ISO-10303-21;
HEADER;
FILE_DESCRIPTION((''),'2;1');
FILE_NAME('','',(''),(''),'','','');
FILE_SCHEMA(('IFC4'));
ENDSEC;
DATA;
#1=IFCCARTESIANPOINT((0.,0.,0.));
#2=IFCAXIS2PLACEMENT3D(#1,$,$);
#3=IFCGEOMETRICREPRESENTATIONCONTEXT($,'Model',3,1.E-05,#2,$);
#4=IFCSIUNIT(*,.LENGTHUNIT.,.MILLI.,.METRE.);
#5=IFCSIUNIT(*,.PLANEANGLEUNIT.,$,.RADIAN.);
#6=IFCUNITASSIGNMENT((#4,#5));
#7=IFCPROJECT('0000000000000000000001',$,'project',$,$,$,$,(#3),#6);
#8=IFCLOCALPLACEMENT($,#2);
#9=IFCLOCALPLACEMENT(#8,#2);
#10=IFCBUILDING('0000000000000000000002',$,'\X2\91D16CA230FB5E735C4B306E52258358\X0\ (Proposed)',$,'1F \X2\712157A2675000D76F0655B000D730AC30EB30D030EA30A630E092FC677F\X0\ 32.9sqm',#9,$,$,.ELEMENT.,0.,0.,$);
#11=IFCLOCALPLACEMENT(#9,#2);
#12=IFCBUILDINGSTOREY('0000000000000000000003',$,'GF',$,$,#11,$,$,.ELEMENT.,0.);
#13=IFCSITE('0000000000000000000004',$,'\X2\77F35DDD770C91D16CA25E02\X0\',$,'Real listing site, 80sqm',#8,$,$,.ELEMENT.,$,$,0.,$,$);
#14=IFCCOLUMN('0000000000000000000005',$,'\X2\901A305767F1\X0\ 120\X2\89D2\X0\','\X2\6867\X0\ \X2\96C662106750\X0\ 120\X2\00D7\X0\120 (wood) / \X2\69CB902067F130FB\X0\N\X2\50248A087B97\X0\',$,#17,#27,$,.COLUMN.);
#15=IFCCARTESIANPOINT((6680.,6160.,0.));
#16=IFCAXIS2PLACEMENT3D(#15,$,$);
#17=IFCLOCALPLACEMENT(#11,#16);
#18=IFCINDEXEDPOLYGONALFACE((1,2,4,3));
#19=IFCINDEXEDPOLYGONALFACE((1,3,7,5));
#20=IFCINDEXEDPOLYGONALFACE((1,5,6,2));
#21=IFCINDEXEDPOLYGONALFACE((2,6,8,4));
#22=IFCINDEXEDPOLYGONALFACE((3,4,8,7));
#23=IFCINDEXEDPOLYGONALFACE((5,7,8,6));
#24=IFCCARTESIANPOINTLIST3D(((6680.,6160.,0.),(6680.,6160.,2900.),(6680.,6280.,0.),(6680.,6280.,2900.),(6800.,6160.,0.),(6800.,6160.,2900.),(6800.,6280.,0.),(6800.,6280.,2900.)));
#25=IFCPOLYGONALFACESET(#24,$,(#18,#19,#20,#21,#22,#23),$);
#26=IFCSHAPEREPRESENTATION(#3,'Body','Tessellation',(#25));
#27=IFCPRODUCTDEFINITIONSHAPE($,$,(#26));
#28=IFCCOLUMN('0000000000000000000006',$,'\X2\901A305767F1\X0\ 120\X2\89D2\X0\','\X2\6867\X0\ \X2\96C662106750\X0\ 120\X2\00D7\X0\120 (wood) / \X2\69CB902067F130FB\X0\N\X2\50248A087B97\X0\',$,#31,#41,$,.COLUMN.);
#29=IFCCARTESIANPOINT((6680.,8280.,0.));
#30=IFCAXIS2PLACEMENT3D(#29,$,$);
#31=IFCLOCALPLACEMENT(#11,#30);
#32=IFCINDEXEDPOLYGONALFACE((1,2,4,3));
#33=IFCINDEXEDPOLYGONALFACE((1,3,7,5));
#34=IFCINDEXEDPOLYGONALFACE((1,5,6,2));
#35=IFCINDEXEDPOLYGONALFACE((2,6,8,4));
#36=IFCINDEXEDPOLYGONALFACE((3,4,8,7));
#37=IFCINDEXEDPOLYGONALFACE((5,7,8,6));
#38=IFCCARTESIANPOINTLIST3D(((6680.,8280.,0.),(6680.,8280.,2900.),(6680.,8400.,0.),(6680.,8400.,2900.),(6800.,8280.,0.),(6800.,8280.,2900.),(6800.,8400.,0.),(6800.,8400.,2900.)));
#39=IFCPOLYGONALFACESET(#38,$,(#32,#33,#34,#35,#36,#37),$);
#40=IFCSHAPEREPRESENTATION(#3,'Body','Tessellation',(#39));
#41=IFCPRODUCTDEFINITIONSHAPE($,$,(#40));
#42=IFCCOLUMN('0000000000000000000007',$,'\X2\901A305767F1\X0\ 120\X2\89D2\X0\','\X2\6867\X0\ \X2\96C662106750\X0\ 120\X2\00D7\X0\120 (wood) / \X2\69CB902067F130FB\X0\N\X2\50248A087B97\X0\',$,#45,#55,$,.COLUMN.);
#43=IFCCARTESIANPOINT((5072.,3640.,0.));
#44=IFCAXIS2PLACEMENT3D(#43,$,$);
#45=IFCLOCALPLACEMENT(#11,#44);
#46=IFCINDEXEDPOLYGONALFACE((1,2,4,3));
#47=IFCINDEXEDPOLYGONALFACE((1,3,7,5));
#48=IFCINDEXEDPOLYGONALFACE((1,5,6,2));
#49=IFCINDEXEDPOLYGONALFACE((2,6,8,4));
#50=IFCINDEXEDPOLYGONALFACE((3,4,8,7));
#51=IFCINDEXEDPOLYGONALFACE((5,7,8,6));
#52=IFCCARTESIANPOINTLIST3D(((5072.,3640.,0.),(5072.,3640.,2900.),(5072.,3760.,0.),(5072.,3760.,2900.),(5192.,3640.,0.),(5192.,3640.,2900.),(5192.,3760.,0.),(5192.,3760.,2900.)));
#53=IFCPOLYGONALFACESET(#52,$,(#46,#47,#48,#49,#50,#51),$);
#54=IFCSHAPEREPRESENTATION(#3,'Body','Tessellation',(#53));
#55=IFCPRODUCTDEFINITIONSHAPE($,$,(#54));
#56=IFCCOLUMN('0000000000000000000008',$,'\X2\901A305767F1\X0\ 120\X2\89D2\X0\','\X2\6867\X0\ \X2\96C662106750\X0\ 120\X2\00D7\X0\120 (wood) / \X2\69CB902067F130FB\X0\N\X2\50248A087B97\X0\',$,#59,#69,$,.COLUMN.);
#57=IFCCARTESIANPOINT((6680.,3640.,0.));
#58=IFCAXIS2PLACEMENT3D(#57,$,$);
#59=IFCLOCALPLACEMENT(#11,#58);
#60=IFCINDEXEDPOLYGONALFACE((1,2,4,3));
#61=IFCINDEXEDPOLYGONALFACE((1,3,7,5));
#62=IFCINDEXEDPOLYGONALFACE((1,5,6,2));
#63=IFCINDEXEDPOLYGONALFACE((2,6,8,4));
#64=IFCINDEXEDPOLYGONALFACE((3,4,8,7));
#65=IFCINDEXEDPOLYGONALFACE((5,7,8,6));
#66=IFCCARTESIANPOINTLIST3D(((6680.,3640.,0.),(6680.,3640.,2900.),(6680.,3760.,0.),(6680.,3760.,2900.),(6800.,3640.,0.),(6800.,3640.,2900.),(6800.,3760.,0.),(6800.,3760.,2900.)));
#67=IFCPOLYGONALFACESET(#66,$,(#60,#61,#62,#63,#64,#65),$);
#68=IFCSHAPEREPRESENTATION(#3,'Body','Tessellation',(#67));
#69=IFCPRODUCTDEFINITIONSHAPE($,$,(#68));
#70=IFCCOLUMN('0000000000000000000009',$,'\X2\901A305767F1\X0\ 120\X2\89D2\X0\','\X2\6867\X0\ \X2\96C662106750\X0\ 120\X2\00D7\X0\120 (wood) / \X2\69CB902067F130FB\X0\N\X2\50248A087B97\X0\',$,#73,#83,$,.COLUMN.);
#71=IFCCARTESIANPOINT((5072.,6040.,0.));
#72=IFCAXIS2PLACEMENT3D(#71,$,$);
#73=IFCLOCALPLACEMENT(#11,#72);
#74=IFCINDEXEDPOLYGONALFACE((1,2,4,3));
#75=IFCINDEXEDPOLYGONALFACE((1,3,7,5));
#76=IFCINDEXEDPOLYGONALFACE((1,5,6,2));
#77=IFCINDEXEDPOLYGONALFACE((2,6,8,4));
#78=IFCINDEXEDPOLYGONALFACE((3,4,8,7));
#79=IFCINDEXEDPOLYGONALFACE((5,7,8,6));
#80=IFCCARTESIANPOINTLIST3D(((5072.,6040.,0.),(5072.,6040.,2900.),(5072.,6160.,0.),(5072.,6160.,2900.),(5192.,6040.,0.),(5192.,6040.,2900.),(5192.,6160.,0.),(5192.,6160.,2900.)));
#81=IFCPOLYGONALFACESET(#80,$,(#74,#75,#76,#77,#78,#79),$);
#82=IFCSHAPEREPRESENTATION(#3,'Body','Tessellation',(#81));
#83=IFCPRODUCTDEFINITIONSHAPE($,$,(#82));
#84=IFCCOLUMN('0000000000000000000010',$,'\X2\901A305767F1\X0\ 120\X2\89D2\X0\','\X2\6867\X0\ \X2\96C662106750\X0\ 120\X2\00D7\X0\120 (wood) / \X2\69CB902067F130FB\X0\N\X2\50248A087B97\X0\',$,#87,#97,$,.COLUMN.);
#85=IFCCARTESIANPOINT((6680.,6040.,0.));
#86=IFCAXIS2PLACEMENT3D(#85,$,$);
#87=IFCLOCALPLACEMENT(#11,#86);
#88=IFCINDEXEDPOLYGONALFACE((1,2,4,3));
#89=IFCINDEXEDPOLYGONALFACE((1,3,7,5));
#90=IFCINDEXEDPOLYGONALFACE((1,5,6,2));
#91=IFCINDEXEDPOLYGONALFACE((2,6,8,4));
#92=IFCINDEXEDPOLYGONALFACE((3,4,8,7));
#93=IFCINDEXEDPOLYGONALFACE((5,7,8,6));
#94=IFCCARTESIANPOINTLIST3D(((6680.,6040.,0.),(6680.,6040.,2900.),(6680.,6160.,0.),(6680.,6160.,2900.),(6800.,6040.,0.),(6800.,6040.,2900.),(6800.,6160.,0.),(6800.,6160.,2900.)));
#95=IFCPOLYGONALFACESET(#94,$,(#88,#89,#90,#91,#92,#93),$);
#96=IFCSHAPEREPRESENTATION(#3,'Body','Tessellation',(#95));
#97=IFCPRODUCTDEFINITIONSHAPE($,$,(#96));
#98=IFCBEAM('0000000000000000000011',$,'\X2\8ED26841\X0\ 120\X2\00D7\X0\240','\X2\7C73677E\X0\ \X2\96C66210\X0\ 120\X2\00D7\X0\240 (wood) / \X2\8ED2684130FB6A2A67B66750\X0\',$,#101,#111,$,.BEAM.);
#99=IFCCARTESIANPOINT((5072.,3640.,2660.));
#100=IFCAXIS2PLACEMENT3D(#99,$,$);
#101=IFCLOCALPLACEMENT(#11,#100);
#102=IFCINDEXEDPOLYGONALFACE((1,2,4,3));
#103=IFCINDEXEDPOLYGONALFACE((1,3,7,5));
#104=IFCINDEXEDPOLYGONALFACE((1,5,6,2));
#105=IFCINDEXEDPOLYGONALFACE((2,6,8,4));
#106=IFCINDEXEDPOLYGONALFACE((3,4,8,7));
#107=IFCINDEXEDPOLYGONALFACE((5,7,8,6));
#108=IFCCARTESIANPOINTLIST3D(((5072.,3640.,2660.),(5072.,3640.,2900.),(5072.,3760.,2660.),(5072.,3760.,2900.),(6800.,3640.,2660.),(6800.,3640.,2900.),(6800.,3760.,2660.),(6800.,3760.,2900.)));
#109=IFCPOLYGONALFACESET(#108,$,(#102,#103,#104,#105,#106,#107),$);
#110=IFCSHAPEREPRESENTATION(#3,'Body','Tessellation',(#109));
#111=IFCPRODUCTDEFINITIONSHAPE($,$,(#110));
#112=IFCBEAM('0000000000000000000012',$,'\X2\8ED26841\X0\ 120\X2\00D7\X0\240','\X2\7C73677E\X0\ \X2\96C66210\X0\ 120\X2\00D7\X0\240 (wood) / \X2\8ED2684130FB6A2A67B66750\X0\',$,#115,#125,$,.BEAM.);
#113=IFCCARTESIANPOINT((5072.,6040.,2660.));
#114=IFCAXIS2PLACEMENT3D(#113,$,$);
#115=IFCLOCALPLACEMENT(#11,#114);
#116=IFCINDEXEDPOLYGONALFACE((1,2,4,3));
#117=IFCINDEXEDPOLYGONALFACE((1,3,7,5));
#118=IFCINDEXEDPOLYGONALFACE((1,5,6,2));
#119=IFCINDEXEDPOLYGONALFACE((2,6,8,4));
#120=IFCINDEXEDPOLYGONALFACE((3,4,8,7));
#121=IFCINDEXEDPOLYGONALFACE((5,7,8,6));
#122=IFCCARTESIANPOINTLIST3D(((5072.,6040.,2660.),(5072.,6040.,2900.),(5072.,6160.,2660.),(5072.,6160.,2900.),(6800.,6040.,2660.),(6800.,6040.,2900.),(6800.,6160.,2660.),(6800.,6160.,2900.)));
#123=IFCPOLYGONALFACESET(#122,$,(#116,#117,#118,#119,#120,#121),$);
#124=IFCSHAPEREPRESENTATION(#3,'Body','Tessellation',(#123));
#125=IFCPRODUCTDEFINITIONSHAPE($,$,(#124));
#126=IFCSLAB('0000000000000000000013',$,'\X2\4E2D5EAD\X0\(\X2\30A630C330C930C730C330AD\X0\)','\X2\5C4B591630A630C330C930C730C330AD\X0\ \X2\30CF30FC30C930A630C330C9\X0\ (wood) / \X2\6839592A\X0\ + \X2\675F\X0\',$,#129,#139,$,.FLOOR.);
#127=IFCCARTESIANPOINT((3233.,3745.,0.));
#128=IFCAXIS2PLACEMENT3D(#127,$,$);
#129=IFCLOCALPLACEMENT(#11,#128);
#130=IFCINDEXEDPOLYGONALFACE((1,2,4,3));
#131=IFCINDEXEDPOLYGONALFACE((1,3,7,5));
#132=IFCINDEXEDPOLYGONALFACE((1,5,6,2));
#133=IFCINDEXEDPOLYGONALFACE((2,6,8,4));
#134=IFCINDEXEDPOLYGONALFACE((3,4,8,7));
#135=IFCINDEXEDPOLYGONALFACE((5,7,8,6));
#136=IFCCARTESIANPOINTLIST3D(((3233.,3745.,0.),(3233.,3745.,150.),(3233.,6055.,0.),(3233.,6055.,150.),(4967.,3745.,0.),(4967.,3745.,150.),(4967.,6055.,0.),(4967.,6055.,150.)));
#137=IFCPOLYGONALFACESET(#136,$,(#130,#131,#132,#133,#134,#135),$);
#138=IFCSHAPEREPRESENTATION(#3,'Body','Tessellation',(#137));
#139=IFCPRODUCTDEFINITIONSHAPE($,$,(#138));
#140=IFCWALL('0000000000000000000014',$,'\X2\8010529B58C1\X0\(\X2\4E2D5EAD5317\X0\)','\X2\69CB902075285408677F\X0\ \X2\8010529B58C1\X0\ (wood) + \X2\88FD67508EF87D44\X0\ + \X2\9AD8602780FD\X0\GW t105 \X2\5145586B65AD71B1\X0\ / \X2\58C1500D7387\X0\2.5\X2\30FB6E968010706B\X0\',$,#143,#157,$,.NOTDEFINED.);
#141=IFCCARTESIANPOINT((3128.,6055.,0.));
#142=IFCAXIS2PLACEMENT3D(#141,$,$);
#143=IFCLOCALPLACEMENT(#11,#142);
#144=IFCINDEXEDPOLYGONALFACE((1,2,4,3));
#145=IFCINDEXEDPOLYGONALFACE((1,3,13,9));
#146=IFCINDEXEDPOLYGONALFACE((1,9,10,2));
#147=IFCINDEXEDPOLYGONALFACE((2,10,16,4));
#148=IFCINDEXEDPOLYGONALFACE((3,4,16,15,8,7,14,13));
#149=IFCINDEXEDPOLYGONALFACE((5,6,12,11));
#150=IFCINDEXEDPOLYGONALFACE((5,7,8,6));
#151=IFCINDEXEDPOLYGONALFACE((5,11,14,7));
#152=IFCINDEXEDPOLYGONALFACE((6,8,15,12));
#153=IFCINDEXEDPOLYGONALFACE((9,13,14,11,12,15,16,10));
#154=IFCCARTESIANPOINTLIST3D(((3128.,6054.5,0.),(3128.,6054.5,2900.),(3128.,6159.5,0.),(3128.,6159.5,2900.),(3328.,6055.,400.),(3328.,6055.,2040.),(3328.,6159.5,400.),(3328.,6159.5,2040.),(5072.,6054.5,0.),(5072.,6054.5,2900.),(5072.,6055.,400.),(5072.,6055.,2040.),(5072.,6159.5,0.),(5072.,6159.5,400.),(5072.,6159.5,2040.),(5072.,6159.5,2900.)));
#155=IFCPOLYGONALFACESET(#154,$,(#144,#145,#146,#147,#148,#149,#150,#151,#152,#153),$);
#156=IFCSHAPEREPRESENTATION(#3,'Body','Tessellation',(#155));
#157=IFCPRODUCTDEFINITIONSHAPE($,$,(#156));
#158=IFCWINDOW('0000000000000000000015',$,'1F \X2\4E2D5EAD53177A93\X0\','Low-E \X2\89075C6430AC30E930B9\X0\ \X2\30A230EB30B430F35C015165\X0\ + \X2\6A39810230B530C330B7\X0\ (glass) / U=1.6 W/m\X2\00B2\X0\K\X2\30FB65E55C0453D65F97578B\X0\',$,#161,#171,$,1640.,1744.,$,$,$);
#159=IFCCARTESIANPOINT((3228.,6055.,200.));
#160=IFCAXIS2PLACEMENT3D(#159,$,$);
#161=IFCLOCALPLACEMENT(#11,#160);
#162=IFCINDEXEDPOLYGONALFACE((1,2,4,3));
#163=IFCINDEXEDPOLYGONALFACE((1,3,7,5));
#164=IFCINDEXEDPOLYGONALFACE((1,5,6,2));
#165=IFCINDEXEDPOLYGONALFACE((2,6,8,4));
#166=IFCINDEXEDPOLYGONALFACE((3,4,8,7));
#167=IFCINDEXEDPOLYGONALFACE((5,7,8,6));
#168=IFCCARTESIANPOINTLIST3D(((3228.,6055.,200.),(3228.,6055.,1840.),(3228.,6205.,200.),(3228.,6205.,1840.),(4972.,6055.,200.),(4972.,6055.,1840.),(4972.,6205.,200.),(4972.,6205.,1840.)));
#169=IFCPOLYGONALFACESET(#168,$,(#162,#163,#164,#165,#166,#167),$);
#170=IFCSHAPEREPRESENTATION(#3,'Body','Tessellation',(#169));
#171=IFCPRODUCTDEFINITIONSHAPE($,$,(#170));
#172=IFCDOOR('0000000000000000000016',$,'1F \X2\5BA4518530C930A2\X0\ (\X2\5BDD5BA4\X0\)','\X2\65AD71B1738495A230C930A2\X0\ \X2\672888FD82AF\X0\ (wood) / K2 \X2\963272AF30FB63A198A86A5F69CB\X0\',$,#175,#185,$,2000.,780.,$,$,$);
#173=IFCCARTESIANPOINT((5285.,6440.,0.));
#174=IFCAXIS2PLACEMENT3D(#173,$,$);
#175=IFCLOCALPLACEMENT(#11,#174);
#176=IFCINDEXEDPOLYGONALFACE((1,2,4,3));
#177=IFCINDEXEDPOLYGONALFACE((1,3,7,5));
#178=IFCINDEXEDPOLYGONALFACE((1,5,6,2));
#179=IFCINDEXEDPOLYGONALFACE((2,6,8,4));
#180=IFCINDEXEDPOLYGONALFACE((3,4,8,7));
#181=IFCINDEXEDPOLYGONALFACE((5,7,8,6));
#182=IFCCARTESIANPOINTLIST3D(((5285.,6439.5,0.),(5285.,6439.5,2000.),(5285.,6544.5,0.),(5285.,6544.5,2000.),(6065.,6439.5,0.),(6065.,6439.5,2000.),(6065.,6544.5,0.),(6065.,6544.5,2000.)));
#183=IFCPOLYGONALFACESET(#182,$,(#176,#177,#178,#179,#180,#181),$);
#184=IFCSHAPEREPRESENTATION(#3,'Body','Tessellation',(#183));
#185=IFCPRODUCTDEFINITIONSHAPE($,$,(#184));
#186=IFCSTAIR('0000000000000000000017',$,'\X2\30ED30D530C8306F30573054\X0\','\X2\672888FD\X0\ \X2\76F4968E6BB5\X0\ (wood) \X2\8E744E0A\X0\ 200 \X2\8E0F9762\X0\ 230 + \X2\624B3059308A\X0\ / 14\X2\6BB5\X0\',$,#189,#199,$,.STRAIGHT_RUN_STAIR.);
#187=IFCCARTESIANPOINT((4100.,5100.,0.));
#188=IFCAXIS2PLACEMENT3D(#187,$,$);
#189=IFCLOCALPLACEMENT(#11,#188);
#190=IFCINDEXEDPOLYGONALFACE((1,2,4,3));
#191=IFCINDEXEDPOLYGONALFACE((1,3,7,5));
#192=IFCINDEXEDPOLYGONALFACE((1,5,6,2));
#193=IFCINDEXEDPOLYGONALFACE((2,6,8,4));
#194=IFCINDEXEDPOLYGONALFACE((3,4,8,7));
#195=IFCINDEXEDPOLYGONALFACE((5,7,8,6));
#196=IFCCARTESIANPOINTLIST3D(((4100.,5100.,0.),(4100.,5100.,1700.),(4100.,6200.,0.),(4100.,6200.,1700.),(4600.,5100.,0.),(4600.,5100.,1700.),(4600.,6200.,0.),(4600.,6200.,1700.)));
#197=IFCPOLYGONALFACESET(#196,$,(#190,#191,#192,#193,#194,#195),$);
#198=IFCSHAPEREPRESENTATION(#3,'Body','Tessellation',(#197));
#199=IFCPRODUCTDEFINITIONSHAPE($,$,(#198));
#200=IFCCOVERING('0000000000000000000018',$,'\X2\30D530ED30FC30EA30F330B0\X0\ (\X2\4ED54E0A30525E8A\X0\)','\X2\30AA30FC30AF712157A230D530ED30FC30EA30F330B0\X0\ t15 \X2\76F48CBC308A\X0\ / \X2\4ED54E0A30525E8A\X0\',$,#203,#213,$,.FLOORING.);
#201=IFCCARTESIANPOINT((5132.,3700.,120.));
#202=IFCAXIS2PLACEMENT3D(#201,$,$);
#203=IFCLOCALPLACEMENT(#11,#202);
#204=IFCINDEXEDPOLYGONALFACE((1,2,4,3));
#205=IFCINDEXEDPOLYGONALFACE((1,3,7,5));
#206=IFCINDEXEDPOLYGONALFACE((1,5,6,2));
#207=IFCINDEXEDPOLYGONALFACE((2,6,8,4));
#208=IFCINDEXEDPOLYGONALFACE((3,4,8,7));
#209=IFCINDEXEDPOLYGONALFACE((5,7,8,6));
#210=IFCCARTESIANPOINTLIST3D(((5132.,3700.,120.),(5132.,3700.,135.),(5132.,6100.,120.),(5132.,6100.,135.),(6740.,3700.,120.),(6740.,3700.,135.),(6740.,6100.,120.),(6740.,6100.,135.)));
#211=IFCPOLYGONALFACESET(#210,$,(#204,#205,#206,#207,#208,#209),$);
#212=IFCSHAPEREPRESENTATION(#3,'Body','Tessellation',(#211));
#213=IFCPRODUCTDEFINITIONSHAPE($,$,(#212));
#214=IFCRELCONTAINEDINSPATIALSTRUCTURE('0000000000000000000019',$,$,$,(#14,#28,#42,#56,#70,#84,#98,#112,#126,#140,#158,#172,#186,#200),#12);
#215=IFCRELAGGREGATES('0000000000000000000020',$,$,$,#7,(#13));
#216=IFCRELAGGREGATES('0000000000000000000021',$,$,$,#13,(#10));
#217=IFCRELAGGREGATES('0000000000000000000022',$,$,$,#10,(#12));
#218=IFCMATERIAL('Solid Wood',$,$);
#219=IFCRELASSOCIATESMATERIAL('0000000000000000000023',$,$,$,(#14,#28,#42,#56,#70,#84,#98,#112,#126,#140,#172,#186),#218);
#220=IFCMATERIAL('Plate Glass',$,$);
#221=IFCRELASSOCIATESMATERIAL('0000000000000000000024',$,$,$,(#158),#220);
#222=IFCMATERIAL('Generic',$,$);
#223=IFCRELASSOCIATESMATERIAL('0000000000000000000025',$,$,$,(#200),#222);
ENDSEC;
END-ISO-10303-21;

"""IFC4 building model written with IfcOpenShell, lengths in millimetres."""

from ifc_helpers import new_model, si_unit, frame, frame_2d, origin, place, context, project, spatial, rectangle, extrude, material, element, fill, save


model = new_model("IFC4")

# Units and contexts
model_context = context("Model", 3, precision=1e-05, world=origin())
ifc_project = project(units=[si_unit("LENGTHUNIT", "METRE", prefix="MILLI"), si_unit("PLANEANGLEUNIT", "RADIAN")], contexts=[model_context])

# Site, building, storey
site_placement = place(None, origin())
site = spatial("IfcSite", under=ifc_project, at=site_placement, Name="石川県金沢市", ObjectType="Real listing site, 80sqm", CompositionType="ELEMENT", RefElevation=0.0)
building_placement = place(site_placement, origin())
building = spatial("IfcBuilding", under=site, at=building_placement, Name="金沢・平屋の別荘 (Proposed)", ObjectType="1F 無垢材×漆喰×ガルバリウム鋼板 32.9sqm", CompositionType="ELEMENT", ElevationOfRefHeight=0.0, ElevationOfTerrain=0.0)
storey_placement = place(building_placement, origin())
storey = spatial("IfcBuildingStorey", under=building, at=storey_placement, Name="GF", CompositionType="ELEMENT", Elevation=0.0)

# Columns
ifc_material_1 = material(Name="Solid Wood")
column_1_placement = place(storey_placement, frame((6680.0, 6160.0, 0.0)))
element("IfcColumn", 1, at=column_1_placement, inside=storey, material=ifc_material_1, Name="通し柱 120角", Description="桧 集成材 120×120 (wood) / 構造柱・N値計算", PredefinedType="COLUMN", context=model_context, shape_type="SweptSolid", body=[
    extrude(rectangle(XDim=120.0, YDim=120.0, at=frame_2d((60.0, 60.0))), frame((6680.0, 6160.0, 0.0)), (0.0, 0.0, 1.0), 2900.0),
])
column_2_placement = place(storey_placement, frame((6680.0, 8280.0, 0.0)))
element("IfcColumn", 2, at=column_2_placement, inside=storey, material=ifc_material_1, Name="通し柱 120角", Description="桧 集成材 120×120 (wood) / 構造柱・N値計算", PredefinedType="COLUMN", context=model_context, shape_type="SweptSolid", body=[
    extrude(rectangle(XDim=120.0, YDim=120.0, at=frame_2d((60.0, 60.0))), frame((6680.0, 8280.0, 0.0)), (0.0, 0.0, 1.0), 2900.0),
])
column_3_placement = place(storey_placement, frame((5072.0, 3640.0, 0.0)))
element("IfcColumn", 3, at=column_3_placement, inside=storey, material=ifc_material_1, Name="通し柱 120角", Description="桧 集成材 120×120 (wood) / 構造柱・N値計算", PredefinedType="COLUMN", context=model_context, shape_type="SweptSolid", body=[
    extrude(rectangle(XDim=120.0, YDim=120.0, at=frame_2d((60.0, 60.0))), frame((5072.0, 3640.0, 0.0)), (0.0, 0.0, 1.0), 2900.0),
])
column_4_placement = place(storey_placement, frame((6680.0, 3640.0, 0.0)))
element("IfcColumn", 4, at=column_4_placement, inside=storey, material=ifc_material_1, Name="通し柱 120角", Description="桧 集成材 120×120 (wood) / 構造柱・N値計算", PredefinedType="COLUMN", context=model_context, shape_type="SweptSolid", body=[
    extrude(rectangle(XDim=120.0, YDim=120.0, at=frame_2d((60.0, 60.0))), frame((6680.0, 3640.0, 0.0)), (0.0, 0.0, 1.0), 2900.0),
])
column_5_placement = place(storey_placement, frame((5072.0, 6040.0, 0.0)))
element("IfcColumn", 5, at=column_5_placement, inside=storey, material=ifc_material_1, Name="通し柱 120角", Description="桧 集成材 120×120 (wood) / 構造柱・N値計算", PredefinedType="COLUMN", context=model_context, shape_type="SweptSolid", body=[
    extrude(rectangle(XDim=120.0, YDim=120.0, at=frame_2d((60.0, 60.0))), frame((5072.0, 6040.0, 0.0)), (0.0, 0.0, 1.0), 2900.0),
])
column_6_placement = place(storey_placement, frame((6680.0, 6040.0, 0.0)))
element("IfcColumn", 6, at=column_6_placement, inside=storey, material=ifc_material_1, Name="通し柱 120角", Description="桧 集成材 120×120 (wood) / 構造柱・N値計算", PredefinedType="COLUMN", context=model_context, shape_type="SweptSolid", body=[
    extrude(rectangle(XDim=120.0, YDim=120.0, at=frame_2d((60.0, 60.0))), frame((6680.0, 6040.0, 0.0)), (0.0, 0.0, 1.0), 2900.0),
])

# Beams
beam_1_placement = place(storey_placement, frame((5072.0, 3640.0, 2660.0)))
element("IfcBeam", 7, at=beam_1_placement, inside=storey, material=ifc_material_1, Name="軒桁 120×240", Description="米松 集成 120×240 (wood) / 軒桁・横架材", PredefinedType="BEAM", context=model_context, shape_type="SweptSolid", body=[
    extrude(rectangle(XDim=1728.0, YDim=120.0, at=frame_2d((864.0, 60.0))), frame((5072.0, 3640.0, 2660.0)), (0.0, 0.0, 1.0), 240.0),
])
beam_2_placement = place(storey_placement, frame((5072.0, 6040.0, 2660.0)))
element("IfcBeam", 8, at=beam_2_placement, inside=storey, material=ifc_material_1, Name="軒桁 120×240", Description="米松 集成 120×240 (wood) / 軒桁・横架材", PredefinedType="BEAM", context=model_context, shape_type="SweptSolid", body=[
    extrude(rectangle(XDim=1728.0, YDim=120.0, at=frame_2d((864.0, 60.0))), frame((5072.0, 6040.0, 2660.0)), (0.0, 0.0, 1.0), 240.0),
])

# Slab
slab_placement = place(storey_placement, frame((3233.0, 3745.0, 0.0)))
element("IfcSlab", 9, at=slab_placement, inside=storey, material=ifc_material_1, Name="中庭(ウッドデッキ)", Description="屋外ウッドデッキ ハードウッド (wood) / 根太 + 束", PredefinedType="FLOOR", context=model_context, shape_type="SweptSolid", body=[
    extrude(rectangle(XDim=1734.0, YDim=2310.0, at=frame_2d((867.0, 1155.0))), frame((3233.0, 3745.0, 0.0)), (0.0, 0.0, 1.0), 150.0),
])

# Wall, opening, window
wall_1_placement = place(storey_placement, frame((3128.0, 6055.0, 0.0)))
wall_1 = element("IfcWall", 10, at=wall_1_placement, inside=storey, material=ifc_material_1, Name="耐力壁(中庭北)", Description="構造用合板 耐力壁 (wood) + 製材軸組 + 高性能GW t105 充填断熱 / 壁倍率2.5・準耐火", PredefinedType="NOTDEFINED", context=model_context, shape_type="SweptSolid", body=[
    extrude(rectangle(XDim=1944.0, YDim=105.0, at=frame_2d((972.0, 52.0))), frame((3128.0, 6055.0, 0.0)), (0.0, 0.0, 1.0), 2900.0),
])
opening_placement = place(storey_placement, frame((3228.0, 6055.0, 200.0)))
opening = element("IfcOpeningElement", 11, at=opening_placement, cuts=wall_1, PredefinedType="NOTDEFINED", context=model_context, shape_type="SweptSolid", body=[
    extrude(rectangle(XDim=1744.0, YDim=150.0, at=frame_2d((872.0, 75.0))), frame((3228.0, 6055.0, 200.0)), (0.0, 0.0, 1.0), 1640.0),
])
ifc_material_2 = material(Name="Plate Glass")
window_placement = place(storey_placement, frame((3228.0, 6055.0, 200.0)))
window = element("IfcWindow", 12, at=window_placement, inside=storey, material=ifc_material_2, Name="1F 中庭北窓", Description="Low-E 複層ガラス アルゴン封入 + 樹脂サッシ (glass) / U=1.6 W/m²K・日射取得型", OverallHeight=1640.0, OverallWidth=1744.0, context=model_context, shape_type="SweptSolid", body=[
    extrude(rectangle(XDim=1744.0, YDim=150.0, at=frame_2d((872.0, 75.0))), frame((3228.0, 6055.0, 200.0)), (0.0, 0.0, 1.0), 1640.0),
])
fill(opening, window)

# Door
door_placement = place(storey_placement, frame((5285.0, 6440.0, 0.0)))
element("IfcDoor", 13, at=door_placement, inside=storey, material=ifc_material_1, Name="1F 室内ドア (寝室)", Description="断熱玄関ドア 木製芯 (wood) / K2 防犯・採風機構", OverallHeight=2000.0, OverallWidth=780.0, context=model_context, shape_type="SweptSolid", body=[
    extrude(rectangle(XDim=780.0, YDim=105.0, at=frame_2d((390.0, 52.0))), frame((5285.0, 6440.0, 0.0)), (0.0, 0.0, 1.0), 2000.0),
])

# Stair
stair_placement = place(storey_placement, frame((4100.0, 5100.0, 0.0)))
element("IfcStair", 14, at=stair_placement, inside=storey, material=ifc_material_1, Name="ロフトはしご", Description="木製 直階段 (wood) 蹴上 200 踏面 230 + 手すり / 14段", PredefinedType="STRAIGHT_RUN_STAIR", context=model_context, shape_type="SweptSolid", body=[
    extrude(rectangle(XDim=500.0, YDim=1100.0, at=frame_2d((250.0, 550.0))), frame((4100.0, 5100.0, 0.0)), (0.0, 0.0, 1.0), 1700.0),
])

# Covering
ifc_material_3 = material(Name="Generic")
covering_placement = place(storey_placement, frame((5132.0, 3700.0, 120.0)))
element("IfcCovering", 15, at=covering_placement, inside=storey, material=ifc_material_3, Name="フローリング (仕上げ床)", Description="オーク無垢フローリング t15 直貼り / 仕上げ床", PredefinedType="FLOORING", context=model_context, shape_type="SweptSolid", body=[
    extrude(rectangle(XDim=1608.0, YDim=2400.0, at=frame_2d((804.0, 1200.0))), frame((5132.0, 3700.0, 120.0)), (0.0, 0.0, 1.0), 15.0),
])

save(model, "model.ifc")
